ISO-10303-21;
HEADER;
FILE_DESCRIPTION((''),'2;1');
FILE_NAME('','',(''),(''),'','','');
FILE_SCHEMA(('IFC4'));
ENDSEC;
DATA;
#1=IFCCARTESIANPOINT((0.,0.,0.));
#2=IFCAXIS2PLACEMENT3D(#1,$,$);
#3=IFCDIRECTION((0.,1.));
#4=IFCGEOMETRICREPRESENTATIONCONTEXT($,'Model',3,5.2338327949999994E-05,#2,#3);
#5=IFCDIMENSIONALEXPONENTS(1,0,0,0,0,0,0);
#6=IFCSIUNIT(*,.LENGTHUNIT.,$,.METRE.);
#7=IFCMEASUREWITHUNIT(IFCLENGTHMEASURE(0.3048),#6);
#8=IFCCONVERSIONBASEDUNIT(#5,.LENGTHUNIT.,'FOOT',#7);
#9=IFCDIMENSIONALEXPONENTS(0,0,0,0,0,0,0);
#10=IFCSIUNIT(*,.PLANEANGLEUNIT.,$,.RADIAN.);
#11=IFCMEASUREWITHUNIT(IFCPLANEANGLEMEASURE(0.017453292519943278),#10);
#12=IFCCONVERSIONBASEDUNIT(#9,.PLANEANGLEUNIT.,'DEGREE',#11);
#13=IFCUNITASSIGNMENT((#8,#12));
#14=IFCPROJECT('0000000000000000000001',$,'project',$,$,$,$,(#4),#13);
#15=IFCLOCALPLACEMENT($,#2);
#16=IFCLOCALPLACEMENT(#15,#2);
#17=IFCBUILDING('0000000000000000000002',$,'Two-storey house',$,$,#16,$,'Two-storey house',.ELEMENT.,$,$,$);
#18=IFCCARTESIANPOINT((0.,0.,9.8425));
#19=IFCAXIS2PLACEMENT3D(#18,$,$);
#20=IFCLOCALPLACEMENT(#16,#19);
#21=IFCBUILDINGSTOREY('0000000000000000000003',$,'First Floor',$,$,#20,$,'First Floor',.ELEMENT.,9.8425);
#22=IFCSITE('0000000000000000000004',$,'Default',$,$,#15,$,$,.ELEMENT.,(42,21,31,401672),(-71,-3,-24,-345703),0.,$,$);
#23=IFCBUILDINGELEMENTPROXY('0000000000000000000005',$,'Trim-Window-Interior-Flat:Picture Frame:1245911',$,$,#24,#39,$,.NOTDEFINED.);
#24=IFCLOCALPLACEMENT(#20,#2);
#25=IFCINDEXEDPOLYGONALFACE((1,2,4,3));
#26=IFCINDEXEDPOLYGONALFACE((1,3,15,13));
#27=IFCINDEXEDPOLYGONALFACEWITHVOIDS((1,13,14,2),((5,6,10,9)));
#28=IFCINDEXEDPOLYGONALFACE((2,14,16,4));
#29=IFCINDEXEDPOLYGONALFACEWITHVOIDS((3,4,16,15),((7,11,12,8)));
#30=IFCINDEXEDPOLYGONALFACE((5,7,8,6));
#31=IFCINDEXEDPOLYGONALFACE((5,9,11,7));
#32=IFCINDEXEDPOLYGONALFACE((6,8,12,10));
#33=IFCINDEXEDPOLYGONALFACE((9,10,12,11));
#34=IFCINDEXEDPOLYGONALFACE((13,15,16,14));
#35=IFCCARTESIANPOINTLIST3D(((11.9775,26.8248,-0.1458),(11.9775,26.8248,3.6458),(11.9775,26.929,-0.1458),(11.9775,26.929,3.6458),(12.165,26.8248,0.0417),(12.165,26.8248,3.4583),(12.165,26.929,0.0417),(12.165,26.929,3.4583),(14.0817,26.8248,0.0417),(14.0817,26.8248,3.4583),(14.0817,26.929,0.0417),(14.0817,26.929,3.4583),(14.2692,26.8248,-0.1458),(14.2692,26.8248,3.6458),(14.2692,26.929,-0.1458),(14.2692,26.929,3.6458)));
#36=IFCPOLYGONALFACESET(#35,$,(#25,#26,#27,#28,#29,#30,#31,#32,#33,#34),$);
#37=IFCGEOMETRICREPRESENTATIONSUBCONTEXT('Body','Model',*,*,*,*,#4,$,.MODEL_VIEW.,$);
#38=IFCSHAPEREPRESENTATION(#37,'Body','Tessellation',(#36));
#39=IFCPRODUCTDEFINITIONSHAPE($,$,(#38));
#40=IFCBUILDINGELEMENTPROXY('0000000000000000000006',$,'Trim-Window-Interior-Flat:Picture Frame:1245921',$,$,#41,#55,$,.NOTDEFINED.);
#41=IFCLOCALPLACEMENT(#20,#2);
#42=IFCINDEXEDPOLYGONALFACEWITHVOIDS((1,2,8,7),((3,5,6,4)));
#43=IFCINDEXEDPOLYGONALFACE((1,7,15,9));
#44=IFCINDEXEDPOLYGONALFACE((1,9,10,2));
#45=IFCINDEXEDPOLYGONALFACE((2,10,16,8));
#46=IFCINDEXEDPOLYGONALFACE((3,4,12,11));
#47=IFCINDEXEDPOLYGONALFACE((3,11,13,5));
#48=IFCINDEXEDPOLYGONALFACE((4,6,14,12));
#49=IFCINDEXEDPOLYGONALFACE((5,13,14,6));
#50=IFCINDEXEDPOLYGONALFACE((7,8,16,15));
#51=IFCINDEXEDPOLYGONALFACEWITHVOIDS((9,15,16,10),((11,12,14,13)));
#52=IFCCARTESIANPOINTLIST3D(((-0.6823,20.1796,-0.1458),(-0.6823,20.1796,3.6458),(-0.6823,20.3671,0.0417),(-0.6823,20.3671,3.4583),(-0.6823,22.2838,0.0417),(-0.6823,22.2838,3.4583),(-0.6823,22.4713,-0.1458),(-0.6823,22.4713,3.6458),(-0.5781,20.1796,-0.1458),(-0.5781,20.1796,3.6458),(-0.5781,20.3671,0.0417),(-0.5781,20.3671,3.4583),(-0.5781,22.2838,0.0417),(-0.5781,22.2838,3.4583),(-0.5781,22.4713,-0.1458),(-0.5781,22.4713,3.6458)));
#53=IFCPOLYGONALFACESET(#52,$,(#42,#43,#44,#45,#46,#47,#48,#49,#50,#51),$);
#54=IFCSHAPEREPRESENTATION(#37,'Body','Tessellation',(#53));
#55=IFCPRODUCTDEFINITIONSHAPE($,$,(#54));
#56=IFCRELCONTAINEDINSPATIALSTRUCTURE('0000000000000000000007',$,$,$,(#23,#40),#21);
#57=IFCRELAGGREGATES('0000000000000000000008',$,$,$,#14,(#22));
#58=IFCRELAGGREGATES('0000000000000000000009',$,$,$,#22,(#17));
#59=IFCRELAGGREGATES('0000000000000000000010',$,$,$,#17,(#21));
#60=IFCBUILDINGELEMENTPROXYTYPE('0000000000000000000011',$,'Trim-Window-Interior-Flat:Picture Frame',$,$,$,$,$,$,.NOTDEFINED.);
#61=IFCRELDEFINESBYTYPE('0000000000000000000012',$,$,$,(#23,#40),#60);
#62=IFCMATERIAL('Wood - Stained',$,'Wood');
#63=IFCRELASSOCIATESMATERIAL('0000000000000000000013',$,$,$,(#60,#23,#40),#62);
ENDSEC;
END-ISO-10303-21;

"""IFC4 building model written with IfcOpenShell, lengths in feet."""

from ifc_helpers import new_model, entity, si_unit, converted_unit, direction, frame, origin, place, context, subcontext, project, spatial, indexed_curve, outline, extrude, source, transform, mapped, material, type_object, type_shapes, element, save


model = new_model("IFC4")

# Units and contexts
model_context = context("Model", 3, precision=5.2338327949999994e-05, world=origin(), true_north=direction((0.0, 1.0)))
body_context = subcontext(model_context, "Body", "Model", "MODEL_VIEW")
ifc_project = project(units=[converted_unit("LENGTHUNIT", "FOOT", entity("IfcLengthMeasure", 0.3048), si_unit("LENGTHUNIT", "METRE"), dimensions=[1, 0, 0, 0, 0, 0, 0]), converted_unit("PLANEANGLEUNIT", "DEGREE", entity("IfcPlaneAngleMeasure", 0.017453292519943278), si_unit("PLANEANGLEUNIT", "RADIAN"), dimensions=[0, 0, 0, 0, 0, 0, 0])], contexts=[model_context])

# Site, building, storey
site_placement = place(None, origin())
site = spatial("IfcSite", under=ifc_project, at=site_placement, Name="Default", CompositionType="ELEMENT", RefLatitude=(42, 21, 31, 401672), RefLongitude=(-71, -3, -24, -345703), RefElevation=0.0)
building_placement = place(site_placement, origin())
building = spatial("IfcBuilding", under=site, at=building_placement, Name="Two-storey house", LongName="Two-storey house", CompositionType="ELEMENT")
storey_placement = place(building_placement, frame((0.0, 0.0, 9.8425)))
storey = spatial("IfcBuildingStorey", under=building, at=storey_placement, Name="First Floor", LongName="First Floor", CompositionType="ELEMENT", Elevation=9.8425)

# Shared definitions
ifc_material_1 = material(Name="Wood - Stained", Category="Wood")

# Building element proxies
building_element_proxy_type_1 = type_object("IfcBuildingElementProxyType", Name="Trim-Window-Interior-Flat:Picture Frame", PredefinedType="NOTDEFINED", material=ifc_material_1)
shared_shape_1 = source(origin(), body_context, "Body", "SweptSolid", [
    extrude(outline(indexed_curve([(-1.1458, -1.8958), (1.1458, -1.8958), (1.1458, 1.8958), (-1.1458, 1.8958), (-1.1458, -1.8958)], self_intersect=False), holes=[indexed_curve([(-0.9583, -1.7083), (-0.9583, 1.7083), (0.9583, 1.7083), (0.9583, -1.7083), (-0.9583, -1.7083)], self_intersect=False)]), frame((0.0, -1.75, 0.0), z_axis=(0.0, 0.0, 1.0), x_axis=(-1.0, 0.0, 0.0)), (0.0, 0.0, 1.0), 0.1042),
])
type_shapes(building_element_proxy_type_1, [shared_shape_1])
for number, where, z_axis, x_axis, name in (
    (1, (13.1234, 26.8248, 3.5), (0.0, 1.0, 0.0), (-1.0, 0.0, 0.0), "Trim-Window-Interior-Flat:Picture Frame:1245911"),
    (2, (-0.5781, 21.3255, 3.5), (-1.0, 0.0, 0.0), (0.0, -1.0, 0.0), "Trim-Window-Interior-Flat:Picture Frame:1245921"),
):
    element("IfcBuildingElementProxy", number, at=place(storey_placement, frame(where, z_axis=z_axis, x_axis=x_axis)), inside=storey, type_object=building_element_proxy_type_1, material=ifc_material_1, Name=name, PredefinedType="NOTDEFINED", context=body_context, shape_type="MappedRepresentation", body=[
        mapped(shared_shape_1, transform((0.0, 0.0, 0.0), scale=1.0)),
    ])

save(model, "model.ifc")
